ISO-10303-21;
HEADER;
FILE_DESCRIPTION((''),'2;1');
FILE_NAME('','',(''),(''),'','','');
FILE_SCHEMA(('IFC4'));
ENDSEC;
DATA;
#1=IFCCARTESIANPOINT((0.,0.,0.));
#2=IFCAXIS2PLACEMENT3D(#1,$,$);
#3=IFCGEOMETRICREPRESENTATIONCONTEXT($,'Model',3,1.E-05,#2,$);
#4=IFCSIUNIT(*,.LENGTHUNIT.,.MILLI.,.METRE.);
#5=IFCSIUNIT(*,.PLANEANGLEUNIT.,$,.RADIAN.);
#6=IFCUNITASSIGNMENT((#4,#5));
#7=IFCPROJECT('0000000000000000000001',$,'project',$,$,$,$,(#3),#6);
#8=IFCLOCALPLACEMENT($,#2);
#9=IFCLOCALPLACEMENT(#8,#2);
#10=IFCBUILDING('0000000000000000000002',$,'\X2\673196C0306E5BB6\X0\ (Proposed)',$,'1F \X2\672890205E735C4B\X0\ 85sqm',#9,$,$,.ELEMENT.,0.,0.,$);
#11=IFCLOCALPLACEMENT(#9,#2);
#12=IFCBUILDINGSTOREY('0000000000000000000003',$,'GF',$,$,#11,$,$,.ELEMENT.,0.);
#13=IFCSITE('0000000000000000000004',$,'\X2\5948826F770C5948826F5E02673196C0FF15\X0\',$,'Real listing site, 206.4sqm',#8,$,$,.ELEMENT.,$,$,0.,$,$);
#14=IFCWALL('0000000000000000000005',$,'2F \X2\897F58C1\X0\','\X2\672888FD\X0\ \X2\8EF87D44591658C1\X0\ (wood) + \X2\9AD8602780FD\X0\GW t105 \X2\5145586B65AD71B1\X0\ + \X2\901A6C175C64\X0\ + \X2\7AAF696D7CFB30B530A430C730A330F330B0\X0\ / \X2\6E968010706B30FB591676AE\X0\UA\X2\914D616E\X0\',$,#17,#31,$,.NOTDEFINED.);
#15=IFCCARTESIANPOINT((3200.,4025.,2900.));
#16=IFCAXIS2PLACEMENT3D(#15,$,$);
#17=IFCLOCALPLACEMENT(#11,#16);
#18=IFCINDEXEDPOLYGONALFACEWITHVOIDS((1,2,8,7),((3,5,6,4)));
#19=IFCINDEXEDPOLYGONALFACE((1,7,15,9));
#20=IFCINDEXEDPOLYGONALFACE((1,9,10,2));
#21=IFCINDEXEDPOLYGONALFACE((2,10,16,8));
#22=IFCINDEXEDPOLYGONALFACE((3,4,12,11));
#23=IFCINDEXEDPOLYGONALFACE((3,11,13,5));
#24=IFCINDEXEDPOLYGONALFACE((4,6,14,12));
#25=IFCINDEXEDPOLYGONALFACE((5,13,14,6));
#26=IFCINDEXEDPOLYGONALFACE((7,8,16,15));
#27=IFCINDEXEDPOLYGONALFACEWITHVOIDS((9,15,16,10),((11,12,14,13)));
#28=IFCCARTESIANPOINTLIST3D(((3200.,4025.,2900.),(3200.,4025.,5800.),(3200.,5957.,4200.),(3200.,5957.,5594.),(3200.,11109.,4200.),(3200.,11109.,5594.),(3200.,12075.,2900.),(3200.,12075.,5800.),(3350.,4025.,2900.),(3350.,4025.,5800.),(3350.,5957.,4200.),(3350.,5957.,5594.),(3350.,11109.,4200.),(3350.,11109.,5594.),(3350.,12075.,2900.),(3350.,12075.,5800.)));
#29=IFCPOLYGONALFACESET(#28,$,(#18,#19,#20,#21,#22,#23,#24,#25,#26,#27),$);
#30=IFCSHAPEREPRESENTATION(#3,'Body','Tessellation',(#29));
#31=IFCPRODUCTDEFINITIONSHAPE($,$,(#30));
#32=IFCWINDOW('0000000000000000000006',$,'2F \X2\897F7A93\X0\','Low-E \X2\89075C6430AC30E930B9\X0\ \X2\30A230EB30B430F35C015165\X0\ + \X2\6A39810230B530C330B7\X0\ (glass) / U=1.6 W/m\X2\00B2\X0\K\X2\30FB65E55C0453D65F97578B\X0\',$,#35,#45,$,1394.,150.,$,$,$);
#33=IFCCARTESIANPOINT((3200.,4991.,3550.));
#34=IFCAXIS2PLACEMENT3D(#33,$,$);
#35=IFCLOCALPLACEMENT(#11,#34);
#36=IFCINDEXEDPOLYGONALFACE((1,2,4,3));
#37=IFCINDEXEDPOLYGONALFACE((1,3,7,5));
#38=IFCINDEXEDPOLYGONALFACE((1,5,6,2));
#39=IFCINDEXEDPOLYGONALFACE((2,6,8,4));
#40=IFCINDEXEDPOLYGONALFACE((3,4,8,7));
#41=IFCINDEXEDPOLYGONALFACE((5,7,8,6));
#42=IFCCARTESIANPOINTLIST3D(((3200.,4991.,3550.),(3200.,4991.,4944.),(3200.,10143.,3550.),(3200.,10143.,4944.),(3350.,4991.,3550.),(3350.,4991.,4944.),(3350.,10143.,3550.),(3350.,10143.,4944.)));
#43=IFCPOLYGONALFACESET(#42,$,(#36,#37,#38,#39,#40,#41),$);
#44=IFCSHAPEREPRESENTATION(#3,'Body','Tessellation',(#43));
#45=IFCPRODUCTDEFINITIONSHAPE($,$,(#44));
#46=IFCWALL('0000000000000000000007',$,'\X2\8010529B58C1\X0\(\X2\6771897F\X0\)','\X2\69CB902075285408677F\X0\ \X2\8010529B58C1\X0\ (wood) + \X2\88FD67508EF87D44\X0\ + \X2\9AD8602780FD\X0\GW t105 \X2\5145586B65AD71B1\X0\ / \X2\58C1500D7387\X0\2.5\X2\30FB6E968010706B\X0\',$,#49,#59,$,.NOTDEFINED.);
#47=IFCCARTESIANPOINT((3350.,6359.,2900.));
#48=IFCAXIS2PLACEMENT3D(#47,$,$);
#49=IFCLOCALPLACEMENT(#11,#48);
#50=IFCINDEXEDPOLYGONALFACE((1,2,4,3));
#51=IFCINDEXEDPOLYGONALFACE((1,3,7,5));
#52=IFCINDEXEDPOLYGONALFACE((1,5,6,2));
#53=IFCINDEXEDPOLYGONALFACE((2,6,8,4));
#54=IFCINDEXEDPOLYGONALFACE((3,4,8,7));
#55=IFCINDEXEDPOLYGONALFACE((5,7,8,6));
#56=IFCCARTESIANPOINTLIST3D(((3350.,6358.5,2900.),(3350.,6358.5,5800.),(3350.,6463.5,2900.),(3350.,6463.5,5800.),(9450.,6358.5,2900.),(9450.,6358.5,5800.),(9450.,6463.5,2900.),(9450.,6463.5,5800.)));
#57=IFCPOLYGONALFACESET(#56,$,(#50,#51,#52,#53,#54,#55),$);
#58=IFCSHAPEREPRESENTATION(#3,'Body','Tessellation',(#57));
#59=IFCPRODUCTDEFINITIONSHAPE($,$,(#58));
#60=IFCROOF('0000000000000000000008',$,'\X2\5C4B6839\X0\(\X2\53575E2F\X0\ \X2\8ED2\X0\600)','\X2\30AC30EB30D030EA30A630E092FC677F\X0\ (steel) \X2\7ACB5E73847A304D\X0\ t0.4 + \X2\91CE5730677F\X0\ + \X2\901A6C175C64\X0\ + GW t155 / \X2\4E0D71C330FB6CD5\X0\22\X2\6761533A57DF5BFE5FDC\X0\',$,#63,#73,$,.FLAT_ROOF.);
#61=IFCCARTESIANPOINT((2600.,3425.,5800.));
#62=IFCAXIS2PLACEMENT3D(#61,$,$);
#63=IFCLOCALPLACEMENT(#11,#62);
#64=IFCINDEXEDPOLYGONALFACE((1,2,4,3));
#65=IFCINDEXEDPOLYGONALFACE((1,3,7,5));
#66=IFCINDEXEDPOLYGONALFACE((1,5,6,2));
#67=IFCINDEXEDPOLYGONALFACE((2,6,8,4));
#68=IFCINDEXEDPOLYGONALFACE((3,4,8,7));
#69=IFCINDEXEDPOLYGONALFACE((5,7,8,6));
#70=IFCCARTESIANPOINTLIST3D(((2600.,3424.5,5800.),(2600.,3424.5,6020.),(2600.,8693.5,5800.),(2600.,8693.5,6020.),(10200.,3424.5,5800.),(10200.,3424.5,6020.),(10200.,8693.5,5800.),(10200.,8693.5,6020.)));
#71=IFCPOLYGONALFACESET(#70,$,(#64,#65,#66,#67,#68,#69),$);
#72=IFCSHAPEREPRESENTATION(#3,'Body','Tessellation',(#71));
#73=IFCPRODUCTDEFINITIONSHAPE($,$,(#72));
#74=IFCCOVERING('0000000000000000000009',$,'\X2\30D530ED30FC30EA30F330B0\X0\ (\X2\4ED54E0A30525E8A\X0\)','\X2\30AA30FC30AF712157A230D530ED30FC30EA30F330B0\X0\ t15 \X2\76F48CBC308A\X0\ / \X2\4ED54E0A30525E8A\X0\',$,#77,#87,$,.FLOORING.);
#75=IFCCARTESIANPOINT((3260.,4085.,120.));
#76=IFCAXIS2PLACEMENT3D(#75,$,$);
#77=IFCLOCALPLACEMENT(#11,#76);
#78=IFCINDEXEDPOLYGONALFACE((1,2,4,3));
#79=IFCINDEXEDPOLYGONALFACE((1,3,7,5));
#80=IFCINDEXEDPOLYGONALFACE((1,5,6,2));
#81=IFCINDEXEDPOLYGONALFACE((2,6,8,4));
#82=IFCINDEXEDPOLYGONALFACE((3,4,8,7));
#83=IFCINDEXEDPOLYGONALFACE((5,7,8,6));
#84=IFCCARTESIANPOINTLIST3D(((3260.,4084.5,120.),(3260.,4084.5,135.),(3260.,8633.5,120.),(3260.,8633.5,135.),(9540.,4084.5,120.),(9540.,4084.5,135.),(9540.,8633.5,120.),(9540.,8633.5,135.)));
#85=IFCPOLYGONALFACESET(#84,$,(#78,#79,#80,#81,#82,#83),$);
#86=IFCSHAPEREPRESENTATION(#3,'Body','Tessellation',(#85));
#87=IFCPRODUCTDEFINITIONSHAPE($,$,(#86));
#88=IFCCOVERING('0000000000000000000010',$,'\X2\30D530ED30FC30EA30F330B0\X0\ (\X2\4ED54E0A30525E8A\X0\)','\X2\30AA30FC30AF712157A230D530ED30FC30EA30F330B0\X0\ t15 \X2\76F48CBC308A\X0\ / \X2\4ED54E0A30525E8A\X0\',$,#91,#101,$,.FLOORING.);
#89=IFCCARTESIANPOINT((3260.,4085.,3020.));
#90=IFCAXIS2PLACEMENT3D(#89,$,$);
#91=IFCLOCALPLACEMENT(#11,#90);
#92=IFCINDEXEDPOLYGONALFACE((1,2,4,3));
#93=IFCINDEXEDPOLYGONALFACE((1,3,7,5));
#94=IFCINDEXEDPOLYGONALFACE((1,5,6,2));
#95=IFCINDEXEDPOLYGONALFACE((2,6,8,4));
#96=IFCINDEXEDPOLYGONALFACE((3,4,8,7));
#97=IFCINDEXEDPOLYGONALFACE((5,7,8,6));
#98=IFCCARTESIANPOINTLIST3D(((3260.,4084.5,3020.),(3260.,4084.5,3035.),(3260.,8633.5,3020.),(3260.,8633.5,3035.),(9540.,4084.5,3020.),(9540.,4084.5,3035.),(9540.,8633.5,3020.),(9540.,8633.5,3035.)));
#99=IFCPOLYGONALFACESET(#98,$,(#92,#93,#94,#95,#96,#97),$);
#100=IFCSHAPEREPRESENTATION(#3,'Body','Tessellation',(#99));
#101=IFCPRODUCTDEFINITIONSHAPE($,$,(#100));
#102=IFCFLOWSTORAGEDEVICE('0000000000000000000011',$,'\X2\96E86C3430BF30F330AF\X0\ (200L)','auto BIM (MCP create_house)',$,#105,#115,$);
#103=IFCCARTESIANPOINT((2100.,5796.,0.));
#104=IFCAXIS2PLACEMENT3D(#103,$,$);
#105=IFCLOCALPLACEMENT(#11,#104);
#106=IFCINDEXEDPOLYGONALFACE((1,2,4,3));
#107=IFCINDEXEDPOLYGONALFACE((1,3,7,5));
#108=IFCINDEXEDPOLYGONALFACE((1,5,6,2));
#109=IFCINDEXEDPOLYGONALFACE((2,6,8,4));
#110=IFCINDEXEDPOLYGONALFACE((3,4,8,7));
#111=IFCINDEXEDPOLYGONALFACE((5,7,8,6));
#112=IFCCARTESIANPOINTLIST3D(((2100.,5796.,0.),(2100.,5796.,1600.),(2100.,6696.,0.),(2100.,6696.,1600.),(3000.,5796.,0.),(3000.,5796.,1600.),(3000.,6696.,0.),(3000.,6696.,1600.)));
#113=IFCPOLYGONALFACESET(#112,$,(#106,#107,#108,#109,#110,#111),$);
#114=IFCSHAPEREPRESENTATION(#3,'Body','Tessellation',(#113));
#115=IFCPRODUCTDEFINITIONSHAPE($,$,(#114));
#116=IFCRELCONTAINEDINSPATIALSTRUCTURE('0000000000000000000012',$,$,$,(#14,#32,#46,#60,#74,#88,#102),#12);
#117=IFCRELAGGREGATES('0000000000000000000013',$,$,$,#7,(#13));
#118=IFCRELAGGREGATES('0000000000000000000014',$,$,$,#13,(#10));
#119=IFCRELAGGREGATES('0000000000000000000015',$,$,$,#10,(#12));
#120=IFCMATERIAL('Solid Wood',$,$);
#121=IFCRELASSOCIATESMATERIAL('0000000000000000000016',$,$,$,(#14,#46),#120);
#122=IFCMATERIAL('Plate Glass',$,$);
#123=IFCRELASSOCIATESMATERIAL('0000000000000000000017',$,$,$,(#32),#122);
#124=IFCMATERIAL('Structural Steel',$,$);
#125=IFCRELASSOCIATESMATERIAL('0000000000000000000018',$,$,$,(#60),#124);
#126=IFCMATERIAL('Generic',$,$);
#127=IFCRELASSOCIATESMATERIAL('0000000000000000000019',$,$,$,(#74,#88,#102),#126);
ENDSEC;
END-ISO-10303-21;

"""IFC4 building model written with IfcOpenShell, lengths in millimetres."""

from ifc_helpers import new_model, si_unit, frame, frame_2d, origin, place, context, project, spatial, rectangle, extrude, material, element, fill, save


model = new_model("IFC4")

# Units and contexts
model_context = context("Model", 3, precision=1e-05, world=origin())
ifc_project = project(units=[si_unit("LENGTHUNIT", "METRE", prefix="MILLI"), si_unit("PLANEANGLEUNIT", "RADIAN")], contexts=[model_context])

# Site, building, storey
site_placement = place(None, origin())
site = spatial("IfcSite", under=ifc_project, at=site_placement, Name="奈良県奈良市朱雀５", ObjectType="Real listing site, 206.4sqm", CompositionType="ELEMENT", RefElevation=0.0)
building_placement = place(site_placement, origin())
building = spatial("IfcBuilding", under=site, at=building_placement, Name="朱雀の家 (Proposed)", ObjectType="1F 木造平屋 85sqm", CompositionType="ELEMENT", ElevationOfRefHeight=0.0, ElevationOfTerrain=0.0)
storey_placement = place(building_placement, origin())
storey = spatial("IfcBuildingStorey", under=building, at=storey_placement, Name="GF", CompositionType="ELEMENT", Elevation=0.0)

# Shared definitions
ifc_material_1 = material(Name="Solid Wood")
ifc_material_2 = material(Name="Generic")

# Shared definitions
ifc_material_3 = material(Name="Plate Glass")

# Wall, opening, window
wall_1_placement = place(storey_placement, frame((3200.0, 4025.0, 2900.0)))
wall_1 = element("IfcWall", 1, at=wall_1_placement, inside=storey, material=ifc_material_1, Name="2F 西壁", Description="木製 軸組外壁 (wood) + 高性能GW t105 充填断熱 + 通気層 + 窯業系サイディング / 準耐火・外皮UA配慮", PredefinedType="NOTDEFINED", context=model_context, shape_type="SweptSolid", body=[
    extrude(rectangle(XDim=150.0, YDim=8050.0, at=frame_2d((75.0, 4025.0))), frame((3200.0, 4025.0, 2900.0)), (0.0, 0.0, 1.0), 2900.0),
])
opening_1_placement = place(storey_placement, frame((3200.0, 4991.0, 3550.0)))
opening_1 = element("IfcOpeningElement", 2, at=opening_1_placement, cuts=wall_1, PredefinedType="NOTDEFINED", context=model_context, shape_type="SweptSolid", body=[
    extrude(rectangle(XDim=150.0, YDim=5152.0, at=frame_2d((75.0, 2576.0))), frame((3200.0, 4991.0, 3550.0)), (0.0, 0.0, 1.0), 1394.0),
])
window_1_placement = place(storey_placement, frame((3200.0, 4991.0, 3550.0)))
window_1 = element("IfcWindow", 3, at=window_1_placement, inside=storey, material=ifc_material_3, Name="2F 西窓", Description="Low-E 複層ガラス アルゴン封入 + 樹脂サッシ (glass) / U=1.6 W/m²K・日射取得型", OverallHeight=1394.0, OverallWidth=150.0, context=model_context, shape_type="SweptSolid", body=[
    extrude(rectangle(XDim=150.0, YDim=5152.0, at=frame_2d((75.0, 2576.0))), frame((3200.0, 4991.0, 3550.0)), (0.0, 0.0, 1.0), 1394.0),
])
fill(opening_1, window_1)

# Wall
wall_2_placement = place(storey_placement, frame((3350.0, 6359.0, 2900.0)))
element("IfcWall", 4, at=wall_2_placement, inside=storey, material=ifc_material_1, Name="耐力壁(東西)", Description="構造用合板 耐力壁 (wood) + 製材軸組 + 高性能GW t105 充填断熱 / 壁倍率2.5・準耐火", PredefinedType="NOTDEFINED", context=model_context, shape_type="SweptSolid", body=[
    extrude(rectangle(XDim=6100.0, YDim=105.0, at=frame_2d((3050.0, 52.0))), frame((3350.0, 6359.0, 2900.0)), (0.0, 0.0, 1.0), 2900.0),
])

# Roof
ifc_material_4 = material(Name="Structural Steel")
for number, where, name in (
    (5, (2600.0, 3425.0, 5800.0), "屋根(南帯 軒600)"),
):
    element("IfcRoof", number, at=place(storey_placement, frame(where)), inside=storey, material=ifc_material_4, Name=name, Description="ガルバリウム鋼板 (steel) 立平葺き t0.4 + 野地板 + 通気層 + GW t155 / 不燃・法22条区域対応", PredefinedType="FLAT_ROOF", context=model_context, shape_type="SweptSolid", body=[
        extrude(rectangle(XDim=7600.0, YDim=5269.0, at=frame_2d((3800.0, 2634.0))), frame((2600.0, 3425.0, 5800.0)), (0.0, 0.0, 1.0), 220.0),
    ])

# Coverings
covering_1_placement = place(storey_placement, frame((3260.0, 4085.0, 120.0)))
element("IfcCovering", 6, at=covering_1_placement, inside=storey, material=ifc_material_2, Name="フローリング (仕上げ床)", Description="オーク無垢フローリング t15 直貼り / 仕上げ床", PredefinedType="FLOORING", context=model_context, shape_type="SweptSolid", body=[
    extrude(rectangle(XDim=6280.0, YDim=4549.0, at=frame_2d((3140.0, 2274.0))), frame((3260.0, 4085.0, 120.0)), (0.0, 0.0, 1.0), 15.0),
])
covering_2_placement = place(storey_placement, frame((3260.0, 4085.0, 3020.0)))
element("IfcCovering", 7, at=covering_2_placement, inside=storey, material=ifc_material_2, Name="フローリング (仕上げ床)", Description="オーク無垢フローリング t15 直貼り / 仕上げ床", PredefinedType="FLOORING", context=model_context, shape_type="SweptSolid", body=[
    extrude(rectangle(XDim=6280.0, YDim=4549.0, at=frame_2d((3140.0, 2274.0))), frame((3260.0, 4085.0, 3020.0)), (0.0, 0.0, 1.0), 15.0),
])

# Flow storage device
flow_storage_device_placement = place(storey_placement, frame((2100.0, 5796.0, 0.0)))
element("IfcFlowStorageDevice", 8, at=flow_storage_device_placement, inside=storey, material=ifc_material_2, Name="雨水タンク (200L)", Description="auto BIM (MCP create_house)", context=model_context, shape_type="SweptSolid", body=[
    extrude(rectangle(XDim=900.0, YDim=900.0, at=frame_2d((450.0, 450.0))), frame((2100.0, 5796.0, 0.0)), (0.0, 0.0, 1.0), 1600.0),
])

save(model, "model.ifc")
